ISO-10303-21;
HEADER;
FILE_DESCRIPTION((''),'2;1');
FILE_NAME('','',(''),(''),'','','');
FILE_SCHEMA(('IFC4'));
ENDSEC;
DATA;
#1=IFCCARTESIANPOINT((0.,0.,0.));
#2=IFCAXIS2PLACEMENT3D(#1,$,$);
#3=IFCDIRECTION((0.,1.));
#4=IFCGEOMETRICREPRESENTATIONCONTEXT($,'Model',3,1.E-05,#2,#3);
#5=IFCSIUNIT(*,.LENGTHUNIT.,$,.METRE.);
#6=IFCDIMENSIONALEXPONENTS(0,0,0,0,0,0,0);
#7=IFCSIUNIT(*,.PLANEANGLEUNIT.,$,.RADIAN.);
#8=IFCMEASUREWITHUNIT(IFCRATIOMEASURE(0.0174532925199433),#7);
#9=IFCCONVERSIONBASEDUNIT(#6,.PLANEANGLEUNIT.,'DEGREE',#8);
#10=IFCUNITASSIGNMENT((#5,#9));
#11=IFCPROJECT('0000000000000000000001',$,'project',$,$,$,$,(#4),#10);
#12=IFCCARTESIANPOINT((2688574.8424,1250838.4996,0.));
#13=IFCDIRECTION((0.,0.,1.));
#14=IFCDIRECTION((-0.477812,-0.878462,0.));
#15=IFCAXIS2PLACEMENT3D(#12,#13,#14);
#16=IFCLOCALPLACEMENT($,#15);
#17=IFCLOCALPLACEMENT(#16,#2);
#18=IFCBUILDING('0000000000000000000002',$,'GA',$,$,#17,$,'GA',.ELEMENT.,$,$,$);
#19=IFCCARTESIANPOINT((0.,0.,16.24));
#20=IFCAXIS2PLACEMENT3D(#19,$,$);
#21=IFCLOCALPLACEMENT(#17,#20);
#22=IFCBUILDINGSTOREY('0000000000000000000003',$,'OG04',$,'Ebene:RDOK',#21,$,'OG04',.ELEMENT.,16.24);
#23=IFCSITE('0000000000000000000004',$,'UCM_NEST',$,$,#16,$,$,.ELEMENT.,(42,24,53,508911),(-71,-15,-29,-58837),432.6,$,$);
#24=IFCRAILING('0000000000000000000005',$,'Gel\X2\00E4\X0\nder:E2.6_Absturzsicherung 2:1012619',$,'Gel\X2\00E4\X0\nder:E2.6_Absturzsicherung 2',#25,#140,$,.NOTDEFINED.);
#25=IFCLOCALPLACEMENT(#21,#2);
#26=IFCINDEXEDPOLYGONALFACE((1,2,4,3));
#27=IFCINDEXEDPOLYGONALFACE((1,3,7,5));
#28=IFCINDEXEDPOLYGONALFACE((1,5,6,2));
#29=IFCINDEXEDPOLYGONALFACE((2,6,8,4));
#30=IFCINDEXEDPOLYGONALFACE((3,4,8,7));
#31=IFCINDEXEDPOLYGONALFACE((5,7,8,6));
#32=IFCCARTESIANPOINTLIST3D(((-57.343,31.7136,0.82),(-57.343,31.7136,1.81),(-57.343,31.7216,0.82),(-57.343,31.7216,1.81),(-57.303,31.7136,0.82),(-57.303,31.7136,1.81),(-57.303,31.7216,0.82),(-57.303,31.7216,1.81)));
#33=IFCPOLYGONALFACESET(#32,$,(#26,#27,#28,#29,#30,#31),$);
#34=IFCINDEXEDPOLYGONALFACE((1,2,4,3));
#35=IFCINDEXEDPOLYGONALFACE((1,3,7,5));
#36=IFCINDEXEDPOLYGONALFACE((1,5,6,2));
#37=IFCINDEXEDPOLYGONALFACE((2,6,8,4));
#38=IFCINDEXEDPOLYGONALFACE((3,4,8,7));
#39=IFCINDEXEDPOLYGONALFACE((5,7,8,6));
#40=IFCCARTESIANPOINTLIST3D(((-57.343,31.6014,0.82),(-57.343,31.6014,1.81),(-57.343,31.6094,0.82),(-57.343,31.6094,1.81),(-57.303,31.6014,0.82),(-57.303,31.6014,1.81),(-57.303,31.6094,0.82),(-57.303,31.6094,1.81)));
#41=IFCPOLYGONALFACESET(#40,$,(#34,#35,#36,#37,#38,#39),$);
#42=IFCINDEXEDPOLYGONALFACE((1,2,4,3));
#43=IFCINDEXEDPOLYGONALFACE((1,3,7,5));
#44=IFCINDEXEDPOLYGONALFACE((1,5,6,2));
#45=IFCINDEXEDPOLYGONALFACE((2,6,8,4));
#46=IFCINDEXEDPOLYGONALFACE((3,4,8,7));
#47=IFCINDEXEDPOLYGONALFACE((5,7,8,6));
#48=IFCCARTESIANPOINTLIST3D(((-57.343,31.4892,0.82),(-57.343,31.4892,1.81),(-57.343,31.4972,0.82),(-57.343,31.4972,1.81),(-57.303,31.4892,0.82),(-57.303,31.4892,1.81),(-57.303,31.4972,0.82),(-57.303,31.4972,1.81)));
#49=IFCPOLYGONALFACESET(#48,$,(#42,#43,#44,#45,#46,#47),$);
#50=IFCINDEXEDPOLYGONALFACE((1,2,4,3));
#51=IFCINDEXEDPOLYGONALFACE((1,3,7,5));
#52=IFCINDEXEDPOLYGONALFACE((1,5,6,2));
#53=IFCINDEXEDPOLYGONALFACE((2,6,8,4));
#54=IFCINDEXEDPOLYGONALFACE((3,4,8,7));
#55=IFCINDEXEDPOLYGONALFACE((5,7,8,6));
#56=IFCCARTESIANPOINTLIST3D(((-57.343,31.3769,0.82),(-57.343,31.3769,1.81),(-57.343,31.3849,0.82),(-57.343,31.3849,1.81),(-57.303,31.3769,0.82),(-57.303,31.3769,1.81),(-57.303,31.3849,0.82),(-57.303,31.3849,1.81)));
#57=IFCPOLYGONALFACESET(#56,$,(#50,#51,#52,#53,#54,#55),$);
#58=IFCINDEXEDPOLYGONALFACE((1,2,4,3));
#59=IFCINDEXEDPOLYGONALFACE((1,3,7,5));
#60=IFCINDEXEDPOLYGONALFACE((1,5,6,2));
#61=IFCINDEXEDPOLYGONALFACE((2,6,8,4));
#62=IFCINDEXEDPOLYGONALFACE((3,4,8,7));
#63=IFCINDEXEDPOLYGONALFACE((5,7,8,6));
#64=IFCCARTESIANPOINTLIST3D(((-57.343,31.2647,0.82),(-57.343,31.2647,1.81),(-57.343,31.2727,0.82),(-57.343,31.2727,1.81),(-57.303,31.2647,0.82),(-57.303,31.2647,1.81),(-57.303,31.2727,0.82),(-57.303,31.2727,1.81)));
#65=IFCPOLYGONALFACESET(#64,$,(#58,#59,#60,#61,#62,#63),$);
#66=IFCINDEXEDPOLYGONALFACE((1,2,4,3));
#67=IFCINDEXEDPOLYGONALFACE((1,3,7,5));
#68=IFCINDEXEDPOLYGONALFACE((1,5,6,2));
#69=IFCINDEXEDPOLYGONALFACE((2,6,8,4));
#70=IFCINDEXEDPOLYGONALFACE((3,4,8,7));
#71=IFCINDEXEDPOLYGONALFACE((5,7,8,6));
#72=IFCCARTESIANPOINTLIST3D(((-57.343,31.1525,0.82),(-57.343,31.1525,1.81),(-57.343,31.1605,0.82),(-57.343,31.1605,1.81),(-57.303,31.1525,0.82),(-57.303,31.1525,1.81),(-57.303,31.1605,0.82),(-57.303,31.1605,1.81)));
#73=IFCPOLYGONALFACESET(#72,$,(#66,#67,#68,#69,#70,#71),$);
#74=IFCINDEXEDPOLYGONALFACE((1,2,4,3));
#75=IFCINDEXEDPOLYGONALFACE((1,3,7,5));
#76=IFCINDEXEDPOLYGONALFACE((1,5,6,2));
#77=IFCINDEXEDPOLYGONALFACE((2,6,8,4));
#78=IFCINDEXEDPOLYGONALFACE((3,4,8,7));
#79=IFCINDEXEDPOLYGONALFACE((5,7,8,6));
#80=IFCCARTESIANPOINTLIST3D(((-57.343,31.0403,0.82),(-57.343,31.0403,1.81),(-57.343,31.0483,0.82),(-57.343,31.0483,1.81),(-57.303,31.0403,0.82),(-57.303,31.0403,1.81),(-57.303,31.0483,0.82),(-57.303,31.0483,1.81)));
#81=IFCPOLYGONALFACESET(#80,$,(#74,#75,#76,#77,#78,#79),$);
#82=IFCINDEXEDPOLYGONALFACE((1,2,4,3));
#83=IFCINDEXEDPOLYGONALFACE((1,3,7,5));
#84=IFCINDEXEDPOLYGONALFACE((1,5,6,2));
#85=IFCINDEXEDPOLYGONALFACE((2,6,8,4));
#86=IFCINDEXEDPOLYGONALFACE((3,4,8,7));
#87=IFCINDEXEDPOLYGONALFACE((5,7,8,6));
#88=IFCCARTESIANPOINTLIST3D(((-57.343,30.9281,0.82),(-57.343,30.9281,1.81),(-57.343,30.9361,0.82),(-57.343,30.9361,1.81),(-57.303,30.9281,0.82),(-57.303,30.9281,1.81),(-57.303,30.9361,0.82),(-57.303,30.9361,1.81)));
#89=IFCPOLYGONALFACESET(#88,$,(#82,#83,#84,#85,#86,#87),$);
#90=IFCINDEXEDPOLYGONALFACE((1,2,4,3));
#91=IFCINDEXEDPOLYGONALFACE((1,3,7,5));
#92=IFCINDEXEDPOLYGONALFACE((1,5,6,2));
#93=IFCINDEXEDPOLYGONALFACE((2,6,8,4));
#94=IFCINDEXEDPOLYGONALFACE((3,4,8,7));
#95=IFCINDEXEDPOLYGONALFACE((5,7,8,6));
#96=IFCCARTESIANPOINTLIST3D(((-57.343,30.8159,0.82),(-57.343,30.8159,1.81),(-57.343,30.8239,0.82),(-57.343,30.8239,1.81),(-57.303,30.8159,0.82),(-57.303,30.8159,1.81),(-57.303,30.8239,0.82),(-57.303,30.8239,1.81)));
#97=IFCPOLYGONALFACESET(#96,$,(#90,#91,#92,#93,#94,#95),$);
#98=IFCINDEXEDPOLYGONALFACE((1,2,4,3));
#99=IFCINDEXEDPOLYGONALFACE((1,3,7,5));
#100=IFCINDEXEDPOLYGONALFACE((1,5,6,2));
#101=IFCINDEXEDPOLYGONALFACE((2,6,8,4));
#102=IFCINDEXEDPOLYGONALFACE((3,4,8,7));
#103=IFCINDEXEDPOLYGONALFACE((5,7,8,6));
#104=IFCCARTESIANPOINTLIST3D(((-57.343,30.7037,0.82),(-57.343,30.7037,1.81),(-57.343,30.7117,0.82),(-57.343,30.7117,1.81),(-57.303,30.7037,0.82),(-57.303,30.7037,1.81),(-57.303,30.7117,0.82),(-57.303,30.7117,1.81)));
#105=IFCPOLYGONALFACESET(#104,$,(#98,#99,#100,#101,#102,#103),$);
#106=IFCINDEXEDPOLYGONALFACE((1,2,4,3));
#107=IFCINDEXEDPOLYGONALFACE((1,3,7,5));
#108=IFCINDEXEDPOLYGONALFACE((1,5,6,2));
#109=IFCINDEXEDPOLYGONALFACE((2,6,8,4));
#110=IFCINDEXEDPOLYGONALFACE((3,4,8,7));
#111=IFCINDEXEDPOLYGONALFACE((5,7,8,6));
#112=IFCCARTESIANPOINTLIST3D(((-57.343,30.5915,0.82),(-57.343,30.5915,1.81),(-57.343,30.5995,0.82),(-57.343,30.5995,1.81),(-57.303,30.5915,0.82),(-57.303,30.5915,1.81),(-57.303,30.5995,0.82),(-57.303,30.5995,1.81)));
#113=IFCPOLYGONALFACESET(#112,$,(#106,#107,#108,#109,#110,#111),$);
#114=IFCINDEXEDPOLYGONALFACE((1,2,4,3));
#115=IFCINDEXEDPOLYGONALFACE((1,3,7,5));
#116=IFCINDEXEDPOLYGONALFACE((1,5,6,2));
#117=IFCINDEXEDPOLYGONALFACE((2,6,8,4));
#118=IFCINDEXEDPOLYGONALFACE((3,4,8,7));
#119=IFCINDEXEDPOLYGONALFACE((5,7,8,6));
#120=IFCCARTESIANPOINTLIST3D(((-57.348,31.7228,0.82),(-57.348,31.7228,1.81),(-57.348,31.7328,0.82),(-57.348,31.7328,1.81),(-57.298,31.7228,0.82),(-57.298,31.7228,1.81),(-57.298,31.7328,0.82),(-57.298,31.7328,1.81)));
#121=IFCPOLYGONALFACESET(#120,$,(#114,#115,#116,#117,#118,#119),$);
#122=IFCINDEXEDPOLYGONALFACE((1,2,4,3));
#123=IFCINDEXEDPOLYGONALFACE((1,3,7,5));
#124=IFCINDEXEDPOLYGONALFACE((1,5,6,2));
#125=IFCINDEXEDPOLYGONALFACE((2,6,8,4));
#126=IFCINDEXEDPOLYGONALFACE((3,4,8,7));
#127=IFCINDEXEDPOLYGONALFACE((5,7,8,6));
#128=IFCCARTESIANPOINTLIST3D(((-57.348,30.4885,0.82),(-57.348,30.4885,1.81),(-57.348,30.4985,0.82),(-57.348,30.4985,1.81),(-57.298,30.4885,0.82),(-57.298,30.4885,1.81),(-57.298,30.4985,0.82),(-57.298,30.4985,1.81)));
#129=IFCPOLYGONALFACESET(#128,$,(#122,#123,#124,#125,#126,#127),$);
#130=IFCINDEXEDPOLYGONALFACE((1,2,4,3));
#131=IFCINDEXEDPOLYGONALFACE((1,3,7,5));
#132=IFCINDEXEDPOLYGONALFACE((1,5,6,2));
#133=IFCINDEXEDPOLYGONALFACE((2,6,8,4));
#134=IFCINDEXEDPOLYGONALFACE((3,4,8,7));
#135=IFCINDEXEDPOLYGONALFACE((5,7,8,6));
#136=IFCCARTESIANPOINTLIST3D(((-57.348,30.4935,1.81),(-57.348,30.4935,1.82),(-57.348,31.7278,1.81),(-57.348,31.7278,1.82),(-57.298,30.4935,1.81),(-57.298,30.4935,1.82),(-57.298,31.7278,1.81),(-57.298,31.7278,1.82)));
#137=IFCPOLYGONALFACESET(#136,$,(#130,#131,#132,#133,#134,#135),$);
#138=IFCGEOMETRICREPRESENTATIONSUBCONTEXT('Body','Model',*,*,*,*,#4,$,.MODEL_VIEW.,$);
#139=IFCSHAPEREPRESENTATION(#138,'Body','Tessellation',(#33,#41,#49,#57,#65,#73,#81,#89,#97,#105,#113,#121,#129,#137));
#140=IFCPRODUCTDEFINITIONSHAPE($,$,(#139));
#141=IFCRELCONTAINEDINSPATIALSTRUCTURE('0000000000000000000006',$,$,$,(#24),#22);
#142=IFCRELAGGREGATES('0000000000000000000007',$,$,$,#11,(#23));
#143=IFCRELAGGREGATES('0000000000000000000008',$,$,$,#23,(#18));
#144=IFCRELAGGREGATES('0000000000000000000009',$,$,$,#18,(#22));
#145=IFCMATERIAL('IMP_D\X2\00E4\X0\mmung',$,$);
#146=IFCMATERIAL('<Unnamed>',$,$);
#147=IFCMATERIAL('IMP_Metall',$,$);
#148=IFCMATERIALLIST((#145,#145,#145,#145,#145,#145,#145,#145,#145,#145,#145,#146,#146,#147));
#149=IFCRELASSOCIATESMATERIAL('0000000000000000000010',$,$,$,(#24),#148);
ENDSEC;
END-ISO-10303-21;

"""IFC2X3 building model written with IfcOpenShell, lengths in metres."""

from ifc_helpers import new_model, entity, si_unit, converted_unit, direction, frame, frame_2d, origin, place, context, subcontext, project, spatial, rectangle, extrude, material, material_list, element, save


model = new_model("IFC2X3")

# Units and contexts
model_context = context("Model", 3, precision=1e-05, world=origin(), true_north=direction((0.0, 1.0)))
body_context = subcontext(model_context, "Body", "Model", "MODEL_VIEW")
ifc_project = project(units=[si_unit("LENGTHUNIT", "METRE"), converted_unit("PLANEANGLEUNIT", "DEGREE", entity("IfcRatioMeasure", 0.0174532925199433), si_unit("PLANEANGLEUNIT", "RADIAN"), dimensions=[0, 0, 0, 0, 0, 0, 0])], contexts=[model_context])

# Site, building, storey
site_placement = place(None, frame((2688574.8424, 1250838.4996, 0.0), z_axis=(0.0, 0.0, 1.0), x_axis=(-0.477812, -0.878462, 0.0)))
site = spatial("IfcSite", under=ifc_project, at=site_placement, Name="UCM_NEST", CompositionType="ELEMENT", RefLatitude=(42, 24, 53, 508911), RefLongitude=(-71, -15, -29, -58837), RefElevation=432.6)
building_placement = place(site_placement, origin())
building = spatial("IfcBuilding", under=site, at=building_placement, Name="GA", LongName="GA", CompositionType="ELEMENT")
storey_placement = place(building_placement, frame((0.0, 0.0, 16.24)))
storey = spatial("IfcBuildingStorey", under=building, at=storey_placement, Name="OG04", ObjectType="Ebene:RDOK", LongName="OG04", CompositionType="ELEMENT", Elevation=16.24)

# Shared definitions
ifc_material_1 = material(Name="<Unnamed>")

# Shared definitions
ifc_material_2 = material(Name="IMP_Dämmung")

# Railing
ifc_material_3 = material(Name="IMP_Metall")
ifc_material_list_1 = material_list([ifc_material_2, ifc_material_2, ifc_material_2, ifc_material_2, ifc_material_2, ifc_material_2, ifc_material_2, ifc_material_2, ifc_material_2, ifc_material_2, ifc_material_2, ifc_material_1, ifc_material_1, ifc_material_3])
railing_1_placement = place(storey_placement, origin())
element("IfcRailing", 1, at=railing_1_placement, inside=storey, material=ifc_material_list_1, Name="Geländer:E2.6_Absturzsicherung 2:1012619", ObjectType="Geländer:E2.6_Absturzsicherung 2", PredefinedType="NOTDEFINED", context=body_context, shape_type="SweptSolid", body=[
    extrude(rectangle(XDim=0.008, YDim=0.04, at=frame_2d((0.0, 0.0), x_axis=(1.0, 0.0))), frame((-57.323, 31.7176, 0.82), z_axis=(0.0, 0.0, 1.0), x_axis=(0.0, 1.0, 0.0)), (0.0, 0.0, 1.0), 0.99),
    extrude(rectangle(XDim=0.008, YDim=0.04, at=frame_2d((0.0, 0.0), x_axis=(1.0, 0.0))), frame((-57.323, 31.6054, 0.82), z_axis=(0.0, 0.0, 1.0), x_axis=(0.0, 1.0, 0.0)), (0.0, 0.0, 1.0), 0.99),
    extrude(rectangle(XDim=0.008, YDim=0.04, at=frame_2d((0.0, 0.0), x_axis=(1.0, 0.0))), frame((-57.323, 31.4932, 0.82), z_axis=(0.0, 0.0, 1.0), x_axis=(0.0, 1.0, 0.0)), (0.0, 0.0, 1.0), 0.99),
    extrude(rectangle(XDim=0.008, YDim=0.04, at=frame_2d((0.0, 0.0), x_axis=(1.0, 0.0))), frame((-57.323, 31.3809, 0.82), z_axis=(0.0, 0.0, 1.0), x_axis=(0.0, 1.0, 0.0)), (0.0, 0.0, 1.0), 0.99),
    extrude(rectangle(XDim=0.008, YDim=0.04, at=frame_2d((0.0, 0.0), x_axis=(1.0, 0.0))), frame((-57.323, 31.2687, 0.82), z_axis=(0.0, 0.0, 1.0), x_axis=(0.0, 1.0, 0.0)), (0.0, 0.0, 1.0), 0.99),
    extrude(rectangle(XDim=0.008, YDim=0.04, at=frame_2d((0.0, 0.0), x_axis=(1.0, 0.0))), frame((-57.323, 31.1565, 0.82), z_axis=(0.0, 0.0, 1.0), x_axis=(0.0, 1.0, 0.0)), (0.0, 0.0, 1.0), 0.99),
    extrude(rectangle(XDim=0.008, YDim=0.04, at=frame_2d((0.0, 0.0), x_axis=(1.0, 0.0))), frame((-57.323, 31.0443, 0.82), z_axis=(0.0, 0.0, 1.0), x_axis=(0.0, 1.0, 0.0)), (0.0, 0.0, 1.0), 0.99),
    extrude(rectangle(XDim=0.008, YDim=0.04, at=frame_2d((0.0, 0.0), x_axis=(1.0, 0.0))), frame((-57.323, 30.9321, 0.82), z_axis=(0.0, 0.0, 1.0), x_axis=(0.0, 1.0, 0.0)), (0.0, 0.0, 1.0), 0.99),
    extrude(rectangle(XDim=0.008, YDim=0.04, at=frame_2d((0.0, 0.0), x_axis=(1.0, 0.0))), frame((-57.323, 30.8199, 0.82), z_axis=(0.0, 0.0, 1.0), x_axis=(0.0, 1.0, 0.0)), (0.0, 0.0, 1.0), 0.99),
    extrude(rectangle(XDim=0.008, YDim=0.04, at=frame_2d((0.0, 0.0), x_axis=(1.0, 0.0))), frame((-57.323, 30.7077, 0.82), z_axis=(0.0, 0.0, 1.0), x_axis=(0.0, 1.0, 0.0)), (0.0, 0.0, 1.0), 0.99),
    extrude(rectangle(XDim=0.008, YDim=0.04, at=frame_2d((0.0, 0.0), x_axis=(1.0, 0.0))), frame((-57.323, 30.5955, 0.82), z_axis=(0.0, 0.0, 1.0), x_axis=(0.0, 1.0, 0.0)), (0.0, 0.0, 1.0), 0.99),
    extrude(rectangle(XDim=0.01, YDim=0.05, at=frame_2d((0.0, 0.0), x_axis=(1.0, 0.0))), frame((-57.323, 31.7278, 0.82), z_axis=(0.0, 0.0, 1.0), x_axis=(0.0, 1.0, 0.0)), (0.0, 0.0, 1.0), 0.99),
    extrude(rectangle(XDim=0.01, YDim=0.05, at=frame_2d((0.0, 0.0), x_axis=(1.0, 0.0))), frame((-57.323, 30.4935, 0.82), z_axis=(0.0, 0.0, 1.0), x_axis=(0.0, 1.0, 0.0)), (0.0, 0.0, 1.0), 0.99),
    extrude(rectangle(XDim=1.2343, YDim=0.05, at=frame_2d((0.0, 0.0), x_axis=(1.0, 0.0))), frame((-57.323, 31.1106, 1.81), z_axis=(0.0, 0.0, 1.0), x_axis=(0.0, 1.0, 0.0)), (0.0, 0.0, 1.0), 0.01),
])

save(model, "model.ifc")
